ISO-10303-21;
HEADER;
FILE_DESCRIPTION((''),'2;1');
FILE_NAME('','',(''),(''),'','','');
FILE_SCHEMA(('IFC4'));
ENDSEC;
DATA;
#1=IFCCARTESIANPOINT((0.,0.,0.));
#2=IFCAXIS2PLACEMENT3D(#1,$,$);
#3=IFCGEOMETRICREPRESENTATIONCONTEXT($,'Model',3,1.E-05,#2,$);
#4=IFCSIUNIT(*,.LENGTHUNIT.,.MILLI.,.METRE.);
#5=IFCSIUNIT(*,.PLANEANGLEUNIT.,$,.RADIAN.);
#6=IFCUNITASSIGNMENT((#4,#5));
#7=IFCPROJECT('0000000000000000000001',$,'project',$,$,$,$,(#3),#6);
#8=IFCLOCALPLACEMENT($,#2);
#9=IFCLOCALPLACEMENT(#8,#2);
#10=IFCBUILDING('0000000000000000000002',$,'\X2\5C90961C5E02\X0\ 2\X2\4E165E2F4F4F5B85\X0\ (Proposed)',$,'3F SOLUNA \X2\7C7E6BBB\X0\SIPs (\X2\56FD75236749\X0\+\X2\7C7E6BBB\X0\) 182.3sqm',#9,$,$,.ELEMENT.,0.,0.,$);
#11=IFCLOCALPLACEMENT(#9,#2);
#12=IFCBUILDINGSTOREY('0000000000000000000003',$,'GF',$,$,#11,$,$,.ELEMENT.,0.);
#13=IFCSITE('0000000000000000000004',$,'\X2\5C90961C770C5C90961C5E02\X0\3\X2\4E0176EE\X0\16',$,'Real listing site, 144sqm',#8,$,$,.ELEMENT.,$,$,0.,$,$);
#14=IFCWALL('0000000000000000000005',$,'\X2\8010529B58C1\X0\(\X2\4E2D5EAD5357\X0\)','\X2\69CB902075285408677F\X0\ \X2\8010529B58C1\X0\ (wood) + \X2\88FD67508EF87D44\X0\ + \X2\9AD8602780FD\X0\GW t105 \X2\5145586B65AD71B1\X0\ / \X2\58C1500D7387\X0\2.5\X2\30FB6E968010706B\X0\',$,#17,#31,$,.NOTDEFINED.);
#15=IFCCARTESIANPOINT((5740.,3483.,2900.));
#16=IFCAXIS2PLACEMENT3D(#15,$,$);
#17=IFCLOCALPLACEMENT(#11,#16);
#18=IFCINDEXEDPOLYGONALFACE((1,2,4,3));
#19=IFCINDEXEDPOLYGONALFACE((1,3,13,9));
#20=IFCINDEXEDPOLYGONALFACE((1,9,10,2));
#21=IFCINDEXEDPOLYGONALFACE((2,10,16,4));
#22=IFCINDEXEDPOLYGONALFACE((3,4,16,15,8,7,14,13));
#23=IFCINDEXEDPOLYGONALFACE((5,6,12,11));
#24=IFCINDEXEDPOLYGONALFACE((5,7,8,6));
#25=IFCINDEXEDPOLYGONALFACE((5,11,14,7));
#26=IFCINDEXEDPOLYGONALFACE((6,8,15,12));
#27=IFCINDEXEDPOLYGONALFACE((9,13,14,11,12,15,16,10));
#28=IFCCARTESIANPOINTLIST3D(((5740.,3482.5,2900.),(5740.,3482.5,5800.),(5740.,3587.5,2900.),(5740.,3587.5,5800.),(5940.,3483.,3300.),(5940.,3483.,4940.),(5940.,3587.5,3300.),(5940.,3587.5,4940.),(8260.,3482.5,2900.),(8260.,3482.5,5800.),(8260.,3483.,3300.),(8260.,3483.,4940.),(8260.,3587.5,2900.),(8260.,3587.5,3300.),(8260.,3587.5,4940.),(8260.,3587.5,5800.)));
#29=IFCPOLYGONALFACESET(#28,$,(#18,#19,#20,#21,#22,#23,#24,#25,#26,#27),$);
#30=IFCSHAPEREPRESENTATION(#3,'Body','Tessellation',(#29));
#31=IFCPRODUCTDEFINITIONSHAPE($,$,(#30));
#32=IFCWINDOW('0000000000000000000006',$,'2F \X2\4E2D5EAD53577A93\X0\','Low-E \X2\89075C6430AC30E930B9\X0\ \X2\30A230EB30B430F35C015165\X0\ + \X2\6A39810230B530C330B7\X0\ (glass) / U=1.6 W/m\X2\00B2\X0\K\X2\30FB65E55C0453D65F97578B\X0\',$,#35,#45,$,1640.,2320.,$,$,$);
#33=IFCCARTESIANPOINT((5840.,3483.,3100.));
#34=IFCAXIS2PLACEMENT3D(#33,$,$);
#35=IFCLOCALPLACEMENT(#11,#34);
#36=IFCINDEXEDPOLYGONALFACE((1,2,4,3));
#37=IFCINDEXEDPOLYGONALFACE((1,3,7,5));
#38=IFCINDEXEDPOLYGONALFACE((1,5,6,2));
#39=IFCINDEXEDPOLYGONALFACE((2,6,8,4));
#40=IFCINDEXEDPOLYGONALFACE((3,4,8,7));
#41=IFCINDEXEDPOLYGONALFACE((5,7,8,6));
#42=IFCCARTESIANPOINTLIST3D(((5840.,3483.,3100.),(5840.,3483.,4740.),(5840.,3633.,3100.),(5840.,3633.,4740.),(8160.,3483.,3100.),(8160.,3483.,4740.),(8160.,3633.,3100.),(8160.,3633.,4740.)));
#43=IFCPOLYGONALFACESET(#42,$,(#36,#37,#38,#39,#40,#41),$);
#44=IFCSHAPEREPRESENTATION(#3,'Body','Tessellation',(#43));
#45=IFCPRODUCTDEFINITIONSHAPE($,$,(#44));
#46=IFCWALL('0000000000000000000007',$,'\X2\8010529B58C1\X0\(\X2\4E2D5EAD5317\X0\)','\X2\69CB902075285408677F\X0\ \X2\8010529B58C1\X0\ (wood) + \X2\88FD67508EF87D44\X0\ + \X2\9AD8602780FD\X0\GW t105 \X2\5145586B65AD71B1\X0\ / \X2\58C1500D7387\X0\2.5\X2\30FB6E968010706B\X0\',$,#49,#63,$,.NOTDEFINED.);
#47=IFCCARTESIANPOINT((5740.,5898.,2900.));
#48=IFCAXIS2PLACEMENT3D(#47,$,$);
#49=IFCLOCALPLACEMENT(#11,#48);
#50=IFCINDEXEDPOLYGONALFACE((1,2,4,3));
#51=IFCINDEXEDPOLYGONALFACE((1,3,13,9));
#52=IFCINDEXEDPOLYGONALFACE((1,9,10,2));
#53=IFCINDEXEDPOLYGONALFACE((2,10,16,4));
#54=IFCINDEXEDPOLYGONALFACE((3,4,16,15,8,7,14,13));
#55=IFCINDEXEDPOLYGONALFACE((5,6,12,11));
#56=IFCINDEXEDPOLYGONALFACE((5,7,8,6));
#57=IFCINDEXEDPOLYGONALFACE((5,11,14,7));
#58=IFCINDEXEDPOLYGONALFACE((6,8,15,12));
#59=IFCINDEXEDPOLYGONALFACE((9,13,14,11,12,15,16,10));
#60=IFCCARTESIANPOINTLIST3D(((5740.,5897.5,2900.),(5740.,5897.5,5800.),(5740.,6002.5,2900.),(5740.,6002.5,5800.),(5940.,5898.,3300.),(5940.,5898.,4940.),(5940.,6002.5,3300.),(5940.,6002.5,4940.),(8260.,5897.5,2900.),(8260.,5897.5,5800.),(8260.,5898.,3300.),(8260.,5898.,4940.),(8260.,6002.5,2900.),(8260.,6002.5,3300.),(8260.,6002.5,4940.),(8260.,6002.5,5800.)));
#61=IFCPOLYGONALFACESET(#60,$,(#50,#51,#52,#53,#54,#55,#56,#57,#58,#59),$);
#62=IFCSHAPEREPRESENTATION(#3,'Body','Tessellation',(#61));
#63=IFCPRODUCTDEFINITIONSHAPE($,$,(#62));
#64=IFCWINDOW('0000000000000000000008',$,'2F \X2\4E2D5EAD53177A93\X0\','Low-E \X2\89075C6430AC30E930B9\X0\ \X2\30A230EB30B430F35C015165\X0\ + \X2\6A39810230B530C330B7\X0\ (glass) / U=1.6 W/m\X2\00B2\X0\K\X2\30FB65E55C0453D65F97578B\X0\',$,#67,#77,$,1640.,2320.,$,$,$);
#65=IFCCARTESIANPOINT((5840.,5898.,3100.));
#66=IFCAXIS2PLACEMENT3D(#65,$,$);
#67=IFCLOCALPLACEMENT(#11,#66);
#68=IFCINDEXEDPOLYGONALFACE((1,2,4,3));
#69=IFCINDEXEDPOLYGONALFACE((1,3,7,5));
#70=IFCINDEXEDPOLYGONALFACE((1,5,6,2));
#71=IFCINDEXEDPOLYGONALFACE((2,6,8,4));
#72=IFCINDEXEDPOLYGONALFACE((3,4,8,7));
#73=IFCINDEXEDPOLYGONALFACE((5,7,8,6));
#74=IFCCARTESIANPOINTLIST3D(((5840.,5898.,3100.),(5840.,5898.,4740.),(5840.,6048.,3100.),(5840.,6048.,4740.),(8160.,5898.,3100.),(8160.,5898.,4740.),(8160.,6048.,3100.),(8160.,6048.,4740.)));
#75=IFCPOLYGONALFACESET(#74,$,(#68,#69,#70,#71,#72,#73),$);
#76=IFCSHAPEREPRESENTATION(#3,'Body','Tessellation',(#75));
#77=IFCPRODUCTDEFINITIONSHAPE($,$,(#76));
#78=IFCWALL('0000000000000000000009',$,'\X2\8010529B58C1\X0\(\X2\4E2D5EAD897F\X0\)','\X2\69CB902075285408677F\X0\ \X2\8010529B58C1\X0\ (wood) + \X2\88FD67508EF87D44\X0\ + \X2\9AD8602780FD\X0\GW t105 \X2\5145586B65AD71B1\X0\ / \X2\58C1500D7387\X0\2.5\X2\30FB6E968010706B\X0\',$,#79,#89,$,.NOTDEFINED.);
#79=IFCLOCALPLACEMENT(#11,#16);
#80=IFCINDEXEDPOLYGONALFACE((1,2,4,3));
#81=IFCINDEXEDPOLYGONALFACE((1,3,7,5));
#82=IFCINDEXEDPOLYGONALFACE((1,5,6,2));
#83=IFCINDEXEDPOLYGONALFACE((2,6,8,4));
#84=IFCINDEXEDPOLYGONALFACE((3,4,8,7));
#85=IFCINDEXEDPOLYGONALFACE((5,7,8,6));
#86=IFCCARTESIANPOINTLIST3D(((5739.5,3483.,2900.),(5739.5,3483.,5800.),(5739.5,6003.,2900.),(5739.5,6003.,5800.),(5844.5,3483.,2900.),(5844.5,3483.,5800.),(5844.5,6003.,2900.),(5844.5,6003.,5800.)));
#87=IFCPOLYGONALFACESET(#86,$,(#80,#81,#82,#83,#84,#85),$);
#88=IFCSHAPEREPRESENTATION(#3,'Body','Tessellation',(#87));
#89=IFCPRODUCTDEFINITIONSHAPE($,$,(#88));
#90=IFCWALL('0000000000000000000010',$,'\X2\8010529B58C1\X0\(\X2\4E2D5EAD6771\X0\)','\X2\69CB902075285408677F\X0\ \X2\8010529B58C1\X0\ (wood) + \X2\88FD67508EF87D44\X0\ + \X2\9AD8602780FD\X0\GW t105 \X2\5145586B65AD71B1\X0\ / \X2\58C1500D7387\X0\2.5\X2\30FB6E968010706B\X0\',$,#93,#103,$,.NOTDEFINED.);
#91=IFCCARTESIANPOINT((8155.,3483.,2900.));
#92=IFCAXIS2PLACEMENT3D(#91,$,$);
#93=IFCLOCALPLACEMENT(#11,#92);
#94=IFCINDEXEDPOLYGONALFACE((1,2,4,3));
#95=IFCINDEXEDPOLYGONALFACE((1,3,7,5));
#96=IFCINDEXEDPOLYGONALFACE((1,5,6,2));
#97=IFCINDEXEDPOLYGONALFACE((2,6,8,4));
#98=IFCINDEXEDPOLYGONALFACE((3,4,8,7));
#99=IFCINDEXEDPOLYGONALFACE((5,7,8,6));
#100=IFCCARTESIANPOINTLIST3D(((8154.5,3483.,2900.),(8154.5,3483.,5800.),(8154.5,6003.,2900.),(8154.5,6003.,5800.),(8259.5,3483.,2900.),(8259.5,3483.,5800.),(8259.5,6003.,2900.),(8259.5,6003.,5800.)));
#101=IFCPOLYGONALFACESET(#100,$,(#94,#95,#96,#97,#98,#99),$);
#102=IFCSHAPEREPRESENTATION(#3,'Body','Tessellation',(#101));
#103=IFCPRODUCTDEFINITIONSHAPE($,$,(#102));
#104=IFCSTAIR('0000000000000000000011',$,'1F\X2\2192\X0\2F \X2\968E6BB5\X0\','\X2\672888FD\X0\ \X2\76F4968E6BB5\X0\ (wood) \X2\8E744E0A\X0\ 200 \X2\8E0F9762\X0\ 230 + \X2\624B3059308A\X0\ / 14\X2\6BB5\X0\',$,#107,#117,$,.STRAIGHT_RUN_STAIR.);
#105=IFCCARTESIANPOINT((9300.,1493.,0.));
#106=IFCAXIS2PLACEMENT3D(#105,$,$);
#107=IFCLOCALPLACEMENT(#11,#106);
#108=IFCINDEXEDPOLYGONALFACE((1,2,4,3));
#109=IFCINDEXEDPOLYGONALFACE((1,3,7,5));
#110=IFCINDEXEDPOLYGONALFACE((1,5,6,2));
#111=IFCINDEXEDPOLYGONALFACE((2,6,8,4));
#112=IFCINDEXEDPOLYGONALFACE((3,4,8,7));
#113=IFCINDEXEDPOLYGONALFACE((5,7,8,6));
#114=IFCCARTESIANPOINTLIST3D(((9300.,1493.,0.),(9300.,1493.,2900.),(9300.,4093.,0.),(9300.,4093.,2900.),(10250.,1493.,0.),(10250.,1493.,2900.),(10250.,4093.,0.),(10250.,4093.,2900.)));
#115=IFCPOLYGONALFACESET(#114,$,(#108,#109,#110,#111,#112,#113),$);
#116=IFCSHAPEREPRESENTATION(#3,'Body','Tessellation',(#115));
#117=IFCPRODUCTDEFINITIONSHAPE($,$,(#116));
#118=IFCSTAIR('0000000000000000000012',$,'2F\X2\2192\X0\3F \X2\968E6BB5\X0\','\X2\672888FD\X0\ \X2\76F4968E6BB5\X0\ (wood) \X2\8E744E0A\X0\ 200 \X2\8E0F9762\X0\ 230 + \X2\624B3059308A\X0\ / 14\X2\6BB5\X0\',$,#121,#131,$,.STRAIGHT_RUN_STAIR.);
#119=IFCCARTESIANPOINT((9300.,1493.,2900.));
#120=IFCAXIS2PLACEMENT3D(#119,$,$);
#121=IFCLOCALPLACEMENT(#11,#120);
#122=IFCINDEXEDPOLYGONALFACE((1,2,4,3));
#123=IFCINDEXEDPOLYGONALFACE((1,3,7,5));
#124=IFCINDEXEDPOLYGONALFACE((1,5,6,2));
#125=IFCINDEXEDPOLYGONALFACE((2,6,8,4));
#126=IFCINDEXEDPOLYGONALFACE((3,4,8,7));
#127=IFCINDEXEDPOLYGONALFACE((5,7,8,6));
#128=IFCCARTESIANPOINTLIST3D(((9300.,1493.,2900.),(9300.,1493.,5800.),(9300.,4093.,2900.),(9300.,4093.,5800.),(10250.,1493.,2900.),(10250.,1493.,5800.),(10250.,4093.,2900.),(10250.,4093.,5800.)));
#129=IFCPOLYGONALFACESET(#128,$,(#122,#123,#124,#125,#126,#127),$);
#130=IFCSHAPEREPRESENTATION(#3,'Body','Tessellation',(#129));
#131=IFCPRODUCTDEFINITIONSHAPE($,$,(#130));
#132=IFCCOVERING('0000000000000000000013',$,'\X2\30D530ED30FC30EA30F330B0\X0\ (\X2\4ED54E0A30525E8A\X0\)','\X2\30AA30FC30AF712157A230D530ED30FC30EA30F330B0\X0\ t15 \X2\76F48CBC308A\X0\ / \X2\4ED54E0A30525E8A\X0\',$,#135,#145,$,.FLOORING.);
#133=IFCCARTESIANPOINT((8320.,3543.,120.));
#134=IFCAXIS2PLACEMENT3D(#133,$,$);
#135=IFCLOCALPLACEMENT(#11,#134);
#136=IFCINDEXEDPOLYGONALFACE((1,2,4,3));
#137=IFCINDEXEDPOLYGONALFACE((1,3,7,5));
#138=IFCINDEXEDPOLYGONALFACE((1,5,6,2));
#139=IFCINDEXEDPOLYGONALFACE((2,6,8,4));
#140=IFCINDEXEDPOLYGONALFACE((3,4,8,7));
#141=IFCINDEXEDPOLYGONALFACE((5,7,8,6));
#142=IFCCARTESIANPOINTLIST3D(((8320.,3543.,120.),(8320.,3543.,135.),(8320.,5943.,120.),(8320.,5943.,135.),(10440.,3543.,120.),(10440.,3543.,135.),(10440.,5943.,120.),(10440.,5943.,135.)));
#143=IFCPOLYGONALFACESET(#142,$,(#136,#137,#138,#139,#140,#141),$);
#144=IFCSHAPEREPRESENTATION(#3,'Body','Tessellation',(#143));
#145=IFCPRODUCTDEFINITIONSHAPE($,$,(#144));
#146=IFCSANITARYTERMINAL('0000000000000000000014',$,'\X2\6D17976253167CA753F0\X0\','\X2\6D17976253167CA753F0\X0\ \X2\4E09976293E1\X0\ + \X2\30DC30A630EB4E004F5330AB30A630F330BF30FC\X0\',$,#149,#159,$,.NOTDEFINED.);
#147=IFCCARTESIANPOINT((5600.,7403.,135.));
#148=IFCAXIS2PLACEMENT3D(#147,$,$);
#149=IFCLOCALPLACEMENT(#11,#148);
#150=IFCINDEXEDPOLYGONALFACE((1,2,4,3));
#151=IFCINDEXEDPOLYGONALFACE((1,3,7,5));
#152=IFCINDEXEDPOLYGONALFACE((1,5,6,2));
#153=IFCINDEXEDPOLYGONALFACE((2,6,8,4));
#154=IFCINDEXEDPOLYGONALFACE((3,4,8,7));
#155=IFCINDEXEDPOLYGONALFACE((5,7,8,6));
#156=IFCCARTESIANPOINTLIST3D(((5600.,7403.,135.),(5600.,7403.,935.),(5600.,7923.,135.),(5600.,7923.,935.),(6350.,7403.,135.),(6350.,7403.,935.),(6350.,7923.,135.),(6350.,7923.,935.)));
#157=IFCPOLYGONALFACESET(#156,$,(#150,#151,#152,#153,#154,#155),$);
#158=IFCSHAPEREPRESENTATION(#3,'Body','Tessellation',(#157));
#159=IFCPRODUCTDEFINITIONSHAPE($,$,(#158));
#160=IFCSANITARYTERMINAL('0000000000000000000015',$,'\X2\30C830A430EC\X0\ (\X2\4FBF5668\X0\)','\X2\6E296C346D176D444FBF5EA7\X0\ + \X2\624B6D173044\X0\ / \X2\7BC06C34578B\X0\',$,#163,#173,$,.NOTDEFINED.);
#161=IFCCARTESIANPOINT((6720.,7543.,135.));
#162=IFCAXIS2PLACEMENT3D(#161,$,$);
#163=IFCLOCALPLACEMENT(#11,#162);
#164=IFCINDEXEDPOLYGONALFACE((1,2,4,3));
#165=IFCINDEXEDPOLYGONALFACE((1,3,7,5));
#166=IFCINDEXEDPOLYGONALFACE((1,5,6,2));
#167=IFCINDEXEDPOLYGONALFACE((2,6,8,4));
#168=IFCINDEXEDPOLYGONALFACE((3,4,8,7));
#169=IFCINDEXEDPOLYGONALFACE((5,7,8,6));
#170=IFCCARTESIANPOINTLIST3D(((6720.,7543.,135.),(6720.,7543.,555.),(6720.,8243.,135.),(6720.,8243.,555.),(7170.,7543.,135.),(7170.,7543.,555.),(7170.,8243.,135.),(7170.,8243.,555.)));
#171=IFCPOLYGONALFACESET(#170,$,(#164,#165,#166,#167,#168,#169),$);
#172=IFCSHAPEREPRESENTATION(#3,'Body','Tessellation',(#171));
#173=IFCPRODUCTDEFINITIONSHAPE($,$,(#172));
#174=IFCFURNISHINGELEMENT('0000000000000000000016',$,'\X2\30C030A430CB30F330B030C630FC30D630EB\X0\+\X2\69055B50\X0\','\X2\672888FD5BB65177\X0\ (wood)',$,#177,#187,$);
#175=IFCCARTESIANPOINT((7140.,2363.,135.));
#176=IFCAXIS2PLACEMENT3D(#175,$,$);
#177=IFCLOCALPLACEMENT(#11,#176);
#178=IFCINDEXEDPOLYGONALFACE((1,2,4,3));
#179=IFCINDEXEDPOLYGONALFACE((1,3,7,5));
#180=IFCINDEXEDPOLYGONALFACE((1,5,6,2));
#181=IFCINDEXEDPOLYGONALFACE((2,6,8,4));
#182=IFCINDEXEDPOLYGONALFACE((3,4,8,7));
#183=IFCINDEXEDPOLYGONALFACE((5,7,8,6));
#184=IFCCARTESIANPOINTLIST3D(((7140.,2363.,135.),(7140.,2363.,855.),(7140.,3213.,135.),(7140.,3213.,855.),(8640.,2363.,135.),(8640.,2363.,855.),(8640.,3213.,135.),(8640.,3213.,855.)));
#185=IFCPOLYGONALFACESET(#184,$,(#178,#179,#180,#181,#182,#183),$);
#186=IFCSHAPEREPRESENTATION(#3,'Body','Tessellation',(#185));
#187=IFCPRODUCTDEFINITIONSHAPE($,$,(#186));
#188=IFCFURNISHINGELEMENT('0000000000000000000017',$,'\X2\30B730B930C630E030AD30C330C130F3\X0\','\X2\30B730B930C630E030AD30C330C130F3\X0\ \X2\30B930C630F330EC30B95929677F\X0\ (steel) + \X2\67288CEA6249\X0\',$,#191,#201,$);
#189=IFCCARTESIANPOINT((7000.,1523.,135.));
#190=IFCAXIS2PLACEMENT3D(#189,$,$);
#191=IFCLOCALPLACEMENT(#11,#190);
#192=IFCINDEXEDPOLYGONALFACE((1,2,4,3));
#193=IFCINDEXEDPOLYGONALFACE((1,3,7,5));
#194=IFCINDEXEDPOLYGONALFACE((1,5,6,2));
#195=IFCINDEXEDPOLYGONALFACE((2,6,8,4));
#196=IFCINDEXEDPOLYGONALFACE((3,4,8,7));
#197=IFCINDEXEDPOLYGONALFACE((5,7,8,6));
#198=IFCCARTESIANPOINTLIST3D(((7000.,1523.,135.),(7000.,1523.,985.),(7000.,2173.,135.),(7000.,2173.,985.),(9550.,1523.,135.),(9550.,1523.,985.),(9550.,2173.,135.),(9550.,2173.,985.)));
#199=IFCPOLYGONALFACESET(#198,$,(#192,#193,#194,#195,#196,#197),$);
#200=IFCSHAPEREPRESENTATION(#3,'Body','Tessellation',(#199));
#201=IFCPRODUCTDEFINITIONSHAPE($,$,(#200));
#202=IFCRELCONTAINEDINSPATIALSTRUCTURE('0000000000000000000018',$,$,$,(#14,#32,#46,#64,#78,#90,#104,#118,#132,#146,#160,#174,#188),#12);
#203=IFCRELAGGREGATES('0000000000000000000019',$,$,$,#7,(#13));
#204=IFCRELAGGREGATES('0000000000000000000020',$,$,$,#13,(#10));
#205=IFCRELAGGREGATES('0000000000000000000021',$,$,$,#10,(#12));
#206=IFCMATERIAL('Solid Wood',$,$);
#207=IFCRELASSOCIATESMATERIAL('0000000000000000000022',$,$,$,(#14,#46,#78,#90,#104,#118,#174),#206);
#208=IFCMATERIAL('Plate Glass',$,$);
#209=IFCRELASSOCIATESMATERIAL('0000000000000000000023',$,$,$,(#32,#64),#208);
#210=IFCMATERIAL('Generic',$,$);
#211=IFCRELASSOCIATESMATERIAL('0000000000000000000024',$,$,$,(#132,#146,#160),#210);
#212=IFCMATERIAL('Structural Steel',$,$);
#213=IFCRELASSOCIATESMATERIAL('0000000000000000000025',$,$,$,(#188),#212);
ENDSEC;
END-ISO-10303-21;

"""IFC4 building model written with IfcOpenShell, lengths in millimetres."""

from ifc_helpers import new_model, si_unit, frame, frame_2d, origin, place, context, project, spatial, rectangle, extrude, material, element, fill, save


model = new_model("IFC4")

# Units and contexts
model_context = context("Model", 3, precision=1e-05, world=origin())
ifc_project = project(units=[si_unit("LENGTHUNIT", "METRE", prefix="MILLI"), si_unit("PLANEANGLEUNIT", "RADIAN")], contexts=[model_context])

# Site, building, storey
site_placement = place(None, origin())
site = spatial("IfcSite", under=ifc_project, at=site_placement, Name="岐阜県岐阜市3丁目16", ObjectType="Real listing site, 144sqm", CompositionType="ELEMENT", RefElevation=0.0)
building_placement = place(site_placement, origin())
building = spatial("IfcBuilding", under=site, at=building_placement, Name="岐阜市 2世帯住宅 (Proposed)", ObjectType="3F SOLUNA 籾殻SIPs (国産杉+籾殻) 182.3sqm", CompositionType="ELEMENT", ElevationOfRefHeight=0.0, ElevationOfTerrain=0.0)
storey_placement = place(building_placement, origin())
storey = spatial("IfcBuildingStorey", under=building, at=storey_placement, Name="GF", CompositionType="ELEMENT", Elevation=0.0)

# Shared definitions
ifc_material_1 = material(Name="Solid Wood")

# Shared definitions
ifc_material_2 = material(Name="Plate Glass")

# Walls, openings, windows
wall_1_placement = place(storey_placement, frame((5740.0, 3483.0, 2900.0)))
wall_1 = element("IfcWall", 1, at=wall_1_placement, inside=storey, material=ifc_material_1, Name="耐力壁(中庭南)", Description="構造用合板 耐力壁 (wood) + 製材軸組 + 高性能GW t105 充填断熱 / 壁倍率2.5・準耐火", PredefinedType="NOTDEFINED", context=model_context, shape_type="SweptSolid", body=[
    extrude(rectangle(XDim=2520.0, YDim=105.0, at=frame_2d((1260.0, 52.0))), frame((5740.0, 3483.0, 2900.0)), (0.0, 0.0, 1.0), 2900.0),
])
opening_1_placement = place(storey_placement, frame((5840.0, 3483.0, 3100.0)))
opening_1 = element("IfcOpeningElement", 2, at=opening_1_placement, cuts=wall_1, PredefinedType="NOTDEFINED", context=model_context, shape_type="SweptSolid", body=[
    extrude(rectangle(XDim=2320.0, YDim=150.0, at=frame_2d((1160.0, 75.0))), frame((5840.0, 3483.0, 3100.0)), (0.0, 0.0, 1.0), 1640.0),
])
window_1_placement = place(storey_placement, frame((5840.0, 3483.0, 3100.0)))
window_1 = element("IfcWindow", 3, at=window_1_placement, inside=storey, material=ifc_material_2, Name="2F 中庭南窓", Description="Low-E 複層ガラス アルゴン封入 + 樹脂サッシ (glass) / U=1.6 W/m²K・日射取得型", OverallHeight=1640.0, OverallWidth=2320.0, context=model_context, shape_type="SweptSolid", body=[
    extrude(rectangle(XDim=2320.0, YDim=150.0, at=frame_2d((1160.0, 75.0))), frame((5840.0, 3483.0, 3100.0)), (0.0, 0.0, 1.0), 1640.0),
])
fill(opening_1, window_1)
wall_2_placement = place(storey_placement, frame((5740.0, 5898.0, 2900.0)))
wall_2 = element("IfcWall", 4, at=wall_2_placement, inside=storey, material=ifc_material_1, Name="耐力壁(中庭北)", Description="構造用合板 耐力壁 (wood) + 製材軸組 + 高性能GW t105 充填断熱 / 壁倍率2.5・準耐火", PredefinedType="NOTDEFINED", context=model_context, shape_type="SweptSolid", body=[
    extrude(rectangle(XDim=2520.0, YDim=105.0, at=frame_2d((1260.0, 52.0))), frame((5740.0, 5898.0, 2900.0)), (0.0, 0.0, 1.0), 2900.0),
])
opening_2_placement = place(storey_placement, frame((5840.0, 5898.0, 3100.0)))
opening_2 = element("IfcOpeningElement", 5, at=opening_2_placement, cuts=wall_2, PredefinedType="NOTDEFINED", context=model_context, shape_type="SweptSolid", body=[
    extrude(rectangle(XDim=2320.0, YDim=150.0, at=frame_2d((1160.0, 75.0))), frame((5840.0, 5898.0, 3100.0)), (0.0, 0.0, 1.0), 1640.0),
])
window_2_placement = place(storey_placement, frame((5840.0, 5898.0, 3100.0)))
window_2 = element("IfcWindow", 6, at=window_2_placement, inside=storey, material=ifc_material_2, Name="2F 中庭北窓", Description="Low-E 複層ガラス アルゴン封入 + 樹脂サッシ (glass) / U=1.6 W/m²K・日射取得型", OverallHeight=1640.0, OverallWidth=2320.0, context=model_context, shape_type="SweptSolid", body=[
    extrude(rectangle(XDim=2320.0, YDim=150.0, at=frame_2d((1160.0, 75.0))), frame((5840.0, 5898.0, 3100.0)), (0.0, 0.0, 1.0), 1640.0),
])
fill(opening_2, window_2)

# Walls
wall_3_placement = place(storey_placement, frame((5740.0, 3483.0, 2900.0)))
element("IfcWall", 7, at=wall_3_placement, inside=storey, material=ifc_material_1, Name="耐力壁(中庭西)", Description="構造用合板 耐力壁 (wood) + 製材軸組 + 高性能GW t105 充填断熱 / 壁倍率2.5・準耐火", PredefinedType="NOTDEFINED", context=model_context, shape_type="SweptSolid", body=[
    extrude(rectangle(XDim=105.0, YDim=2520.0, at=frame_2d((52.0, 1260.0))), frame((5740.0, 3483.0, 2900.0)), (0.0, 0.0, 1.0), 2900.0),
])
wall_4_placement = place(storey_placement, frame((8155.0, 3483.0, 2900.0)))
element("IfcWall", 8, at=wall_4_placement, inside=storey, material=ifc_material_1, Name="耐力壁(中庭東)", Description="構造用合板 耐力壁 (wood) + 製材軸組 + 高性能GW t105 充填断熱 / 壁倍率2.5・準耐火", PredefinedType="NOTDEFINED", context=model_context, shape_type="SweptSolid", body=[
    extrude(rectangle(XDim=105.0, YDim=2520.0, at=frame_2d((52.0, 1260.0))), frame((8155.0, 3483.0, 2900.0)), (0.0, 0.0, 1.0), 2900.0),
])

# Stairs
stair_1_placement = place(storey_placement, frame((9300.0, 1493.0, 0.0)))
element("IfcStair", 9, at=stair_1_placement, inside=storey, material=ifc_material_1, Name="1F→2F 階段", Description="木製 直階段 (wood) 蹴上 200 踏面 230 + 手すり / 14段", PredefinedType="STRAIGHT_RUN_STAIR", context=model_context, shape_type="SweptSolid", body=[
    extrude(rectangle(XDim=950.0, YDim=2600.0, at=frame_2d((475.0, 1300.0))), frame((9300.0, 1493.0, 0.0)), (0.0, 0.0, 1.0), 2900.0),
])
stair_2_placement = place(storey_placement, frame((9300.0, 1493.0, 2900.0)))
element("IfcStair", 10, at=stair_2_placement, inside=storey, material=ifc_material_1, Name="2F→3F 階段", Description="木製 直階段 (wood) 蹴上 200 踏面 230 + 手すり / 14段", PredefinedType="STRAIGHT_RUN_STAIR", context=model_context, shape_type="SweptSolid", body=[
    extrude(rectangle(XDim=950.0, YDim=2600.0, at=frame_2d((475.0, 1300.0))), frame((9300.0, 1493.0, 2900.0)), (0.0, 0.0, 1.0), 2900.0),
])

# Covering
ifc_material_3 = material(Name="Generic")
covering_placement = place(storey_placement, frame((8320.0, 3543.0, 120.0)))
element("IfcCovering", 11, at=covering_placement, inside=storey, material=ifc_material_3, Name="フローリング (仕上げ床)", Description="オーク無垢フローリング t15 直貼り / 仕上げ床", PredefinedType="FLOORING", context=model_context, shape_type="SweptSolid", body=[
    extrude(rectangle(XDim=2120.0, YDim=2400.0, at=frame_2d((1060.0, 1200.0))), frame((8320.0, 3543.0, 120.0)), (0.0, 0.0, 1.0), 15.0),
])

# Sanitary terminals
sanitary_terminal_1_placement = place(storey_placement, frame((5600.0, 7403.0, 135.0)))
element("IfcSanitaryTerminal", 12, at=sanitary_terminal_1_placement, inside=storey, material=ifc_material_3, Name="洗面化粧台", Description="洗面化粧台 三面鏡 + ボウル一体カウンター", PredefinedType="NOTDEFINED", context=model_context, shape_type="SweptSolid", body=[
    extrude(rectangle(XDim=750.0, YDim=520.0, at=frame_2d((375.0, 260.0))), frame((5600.0, 7403.0, 135.0)), (0.0, 0.0, 1.0), 800.0),
])
sanitary_terminal_2_placement = place(storey_placement, frame((6720.0, 7543.0, 135.0)))
element("IfcSanitaryTerminal", 13, at=sanitary_terminal_2_placement, inside=storey, material=ifc_material_3, Name="トイレ (便器)", Description="温水洗浄便座 + 手洗い / 節水型", PredefinedType="NOTDEFINED", context=model_context, shape_type="SweptSolid", body=[
    extrude(rectangle(XDim=450.0, YDim=700.0, at=frame_2d((225.0, 350.0))), frame((6720.0, 7543.0, 135.0)), (0.0, 0.0, 1.0), 420.0),
])

# Furnishing elements
furnishing_1_placement = place(storey_placement, frame((7140.0, 2363.0, 135.0)))
element("IfcFurnishingElement", 14, at=furnishing_1_placement, inside=storey, material=ifc_material_1, Name="ダイニングテーブル+椅子", Description="木製家具 (wood)", context=model_context, shape_type="SweptSolid", body=[
    extrude(rectangle(XDim=1500.0, YDim=850.0, at=frame_2d((750.0, 425.0))), frame((7140.0, 2363.0, 135.0)), (0.0, 0.0, 1.0), 720.0),
])
ifc_material_4 = material(Name="Structural Steel")
furnishing_2_placement = place(storey_placement, frame((7000.0, 1523.0, 135.0)))
element("IfcFurnishingElement", 15, at=furnishing_2_placement, inside=storey, material=ifc_material_4, Name="システムキッチン", Description="システムキッチン ステンレス天板 (steel) + 木質扉", context=model_context, shape_type="SweptSolid", body=[
    extrude(rectangle(XDim=2550.0, YDim=650.0, at=frame_2d((1275.0, 325.0))), frame((7000.0, 1523.0, 135.0)), (0.0, 0.0, 1.0), 850.0),
])

save(model, "model.ifc")
